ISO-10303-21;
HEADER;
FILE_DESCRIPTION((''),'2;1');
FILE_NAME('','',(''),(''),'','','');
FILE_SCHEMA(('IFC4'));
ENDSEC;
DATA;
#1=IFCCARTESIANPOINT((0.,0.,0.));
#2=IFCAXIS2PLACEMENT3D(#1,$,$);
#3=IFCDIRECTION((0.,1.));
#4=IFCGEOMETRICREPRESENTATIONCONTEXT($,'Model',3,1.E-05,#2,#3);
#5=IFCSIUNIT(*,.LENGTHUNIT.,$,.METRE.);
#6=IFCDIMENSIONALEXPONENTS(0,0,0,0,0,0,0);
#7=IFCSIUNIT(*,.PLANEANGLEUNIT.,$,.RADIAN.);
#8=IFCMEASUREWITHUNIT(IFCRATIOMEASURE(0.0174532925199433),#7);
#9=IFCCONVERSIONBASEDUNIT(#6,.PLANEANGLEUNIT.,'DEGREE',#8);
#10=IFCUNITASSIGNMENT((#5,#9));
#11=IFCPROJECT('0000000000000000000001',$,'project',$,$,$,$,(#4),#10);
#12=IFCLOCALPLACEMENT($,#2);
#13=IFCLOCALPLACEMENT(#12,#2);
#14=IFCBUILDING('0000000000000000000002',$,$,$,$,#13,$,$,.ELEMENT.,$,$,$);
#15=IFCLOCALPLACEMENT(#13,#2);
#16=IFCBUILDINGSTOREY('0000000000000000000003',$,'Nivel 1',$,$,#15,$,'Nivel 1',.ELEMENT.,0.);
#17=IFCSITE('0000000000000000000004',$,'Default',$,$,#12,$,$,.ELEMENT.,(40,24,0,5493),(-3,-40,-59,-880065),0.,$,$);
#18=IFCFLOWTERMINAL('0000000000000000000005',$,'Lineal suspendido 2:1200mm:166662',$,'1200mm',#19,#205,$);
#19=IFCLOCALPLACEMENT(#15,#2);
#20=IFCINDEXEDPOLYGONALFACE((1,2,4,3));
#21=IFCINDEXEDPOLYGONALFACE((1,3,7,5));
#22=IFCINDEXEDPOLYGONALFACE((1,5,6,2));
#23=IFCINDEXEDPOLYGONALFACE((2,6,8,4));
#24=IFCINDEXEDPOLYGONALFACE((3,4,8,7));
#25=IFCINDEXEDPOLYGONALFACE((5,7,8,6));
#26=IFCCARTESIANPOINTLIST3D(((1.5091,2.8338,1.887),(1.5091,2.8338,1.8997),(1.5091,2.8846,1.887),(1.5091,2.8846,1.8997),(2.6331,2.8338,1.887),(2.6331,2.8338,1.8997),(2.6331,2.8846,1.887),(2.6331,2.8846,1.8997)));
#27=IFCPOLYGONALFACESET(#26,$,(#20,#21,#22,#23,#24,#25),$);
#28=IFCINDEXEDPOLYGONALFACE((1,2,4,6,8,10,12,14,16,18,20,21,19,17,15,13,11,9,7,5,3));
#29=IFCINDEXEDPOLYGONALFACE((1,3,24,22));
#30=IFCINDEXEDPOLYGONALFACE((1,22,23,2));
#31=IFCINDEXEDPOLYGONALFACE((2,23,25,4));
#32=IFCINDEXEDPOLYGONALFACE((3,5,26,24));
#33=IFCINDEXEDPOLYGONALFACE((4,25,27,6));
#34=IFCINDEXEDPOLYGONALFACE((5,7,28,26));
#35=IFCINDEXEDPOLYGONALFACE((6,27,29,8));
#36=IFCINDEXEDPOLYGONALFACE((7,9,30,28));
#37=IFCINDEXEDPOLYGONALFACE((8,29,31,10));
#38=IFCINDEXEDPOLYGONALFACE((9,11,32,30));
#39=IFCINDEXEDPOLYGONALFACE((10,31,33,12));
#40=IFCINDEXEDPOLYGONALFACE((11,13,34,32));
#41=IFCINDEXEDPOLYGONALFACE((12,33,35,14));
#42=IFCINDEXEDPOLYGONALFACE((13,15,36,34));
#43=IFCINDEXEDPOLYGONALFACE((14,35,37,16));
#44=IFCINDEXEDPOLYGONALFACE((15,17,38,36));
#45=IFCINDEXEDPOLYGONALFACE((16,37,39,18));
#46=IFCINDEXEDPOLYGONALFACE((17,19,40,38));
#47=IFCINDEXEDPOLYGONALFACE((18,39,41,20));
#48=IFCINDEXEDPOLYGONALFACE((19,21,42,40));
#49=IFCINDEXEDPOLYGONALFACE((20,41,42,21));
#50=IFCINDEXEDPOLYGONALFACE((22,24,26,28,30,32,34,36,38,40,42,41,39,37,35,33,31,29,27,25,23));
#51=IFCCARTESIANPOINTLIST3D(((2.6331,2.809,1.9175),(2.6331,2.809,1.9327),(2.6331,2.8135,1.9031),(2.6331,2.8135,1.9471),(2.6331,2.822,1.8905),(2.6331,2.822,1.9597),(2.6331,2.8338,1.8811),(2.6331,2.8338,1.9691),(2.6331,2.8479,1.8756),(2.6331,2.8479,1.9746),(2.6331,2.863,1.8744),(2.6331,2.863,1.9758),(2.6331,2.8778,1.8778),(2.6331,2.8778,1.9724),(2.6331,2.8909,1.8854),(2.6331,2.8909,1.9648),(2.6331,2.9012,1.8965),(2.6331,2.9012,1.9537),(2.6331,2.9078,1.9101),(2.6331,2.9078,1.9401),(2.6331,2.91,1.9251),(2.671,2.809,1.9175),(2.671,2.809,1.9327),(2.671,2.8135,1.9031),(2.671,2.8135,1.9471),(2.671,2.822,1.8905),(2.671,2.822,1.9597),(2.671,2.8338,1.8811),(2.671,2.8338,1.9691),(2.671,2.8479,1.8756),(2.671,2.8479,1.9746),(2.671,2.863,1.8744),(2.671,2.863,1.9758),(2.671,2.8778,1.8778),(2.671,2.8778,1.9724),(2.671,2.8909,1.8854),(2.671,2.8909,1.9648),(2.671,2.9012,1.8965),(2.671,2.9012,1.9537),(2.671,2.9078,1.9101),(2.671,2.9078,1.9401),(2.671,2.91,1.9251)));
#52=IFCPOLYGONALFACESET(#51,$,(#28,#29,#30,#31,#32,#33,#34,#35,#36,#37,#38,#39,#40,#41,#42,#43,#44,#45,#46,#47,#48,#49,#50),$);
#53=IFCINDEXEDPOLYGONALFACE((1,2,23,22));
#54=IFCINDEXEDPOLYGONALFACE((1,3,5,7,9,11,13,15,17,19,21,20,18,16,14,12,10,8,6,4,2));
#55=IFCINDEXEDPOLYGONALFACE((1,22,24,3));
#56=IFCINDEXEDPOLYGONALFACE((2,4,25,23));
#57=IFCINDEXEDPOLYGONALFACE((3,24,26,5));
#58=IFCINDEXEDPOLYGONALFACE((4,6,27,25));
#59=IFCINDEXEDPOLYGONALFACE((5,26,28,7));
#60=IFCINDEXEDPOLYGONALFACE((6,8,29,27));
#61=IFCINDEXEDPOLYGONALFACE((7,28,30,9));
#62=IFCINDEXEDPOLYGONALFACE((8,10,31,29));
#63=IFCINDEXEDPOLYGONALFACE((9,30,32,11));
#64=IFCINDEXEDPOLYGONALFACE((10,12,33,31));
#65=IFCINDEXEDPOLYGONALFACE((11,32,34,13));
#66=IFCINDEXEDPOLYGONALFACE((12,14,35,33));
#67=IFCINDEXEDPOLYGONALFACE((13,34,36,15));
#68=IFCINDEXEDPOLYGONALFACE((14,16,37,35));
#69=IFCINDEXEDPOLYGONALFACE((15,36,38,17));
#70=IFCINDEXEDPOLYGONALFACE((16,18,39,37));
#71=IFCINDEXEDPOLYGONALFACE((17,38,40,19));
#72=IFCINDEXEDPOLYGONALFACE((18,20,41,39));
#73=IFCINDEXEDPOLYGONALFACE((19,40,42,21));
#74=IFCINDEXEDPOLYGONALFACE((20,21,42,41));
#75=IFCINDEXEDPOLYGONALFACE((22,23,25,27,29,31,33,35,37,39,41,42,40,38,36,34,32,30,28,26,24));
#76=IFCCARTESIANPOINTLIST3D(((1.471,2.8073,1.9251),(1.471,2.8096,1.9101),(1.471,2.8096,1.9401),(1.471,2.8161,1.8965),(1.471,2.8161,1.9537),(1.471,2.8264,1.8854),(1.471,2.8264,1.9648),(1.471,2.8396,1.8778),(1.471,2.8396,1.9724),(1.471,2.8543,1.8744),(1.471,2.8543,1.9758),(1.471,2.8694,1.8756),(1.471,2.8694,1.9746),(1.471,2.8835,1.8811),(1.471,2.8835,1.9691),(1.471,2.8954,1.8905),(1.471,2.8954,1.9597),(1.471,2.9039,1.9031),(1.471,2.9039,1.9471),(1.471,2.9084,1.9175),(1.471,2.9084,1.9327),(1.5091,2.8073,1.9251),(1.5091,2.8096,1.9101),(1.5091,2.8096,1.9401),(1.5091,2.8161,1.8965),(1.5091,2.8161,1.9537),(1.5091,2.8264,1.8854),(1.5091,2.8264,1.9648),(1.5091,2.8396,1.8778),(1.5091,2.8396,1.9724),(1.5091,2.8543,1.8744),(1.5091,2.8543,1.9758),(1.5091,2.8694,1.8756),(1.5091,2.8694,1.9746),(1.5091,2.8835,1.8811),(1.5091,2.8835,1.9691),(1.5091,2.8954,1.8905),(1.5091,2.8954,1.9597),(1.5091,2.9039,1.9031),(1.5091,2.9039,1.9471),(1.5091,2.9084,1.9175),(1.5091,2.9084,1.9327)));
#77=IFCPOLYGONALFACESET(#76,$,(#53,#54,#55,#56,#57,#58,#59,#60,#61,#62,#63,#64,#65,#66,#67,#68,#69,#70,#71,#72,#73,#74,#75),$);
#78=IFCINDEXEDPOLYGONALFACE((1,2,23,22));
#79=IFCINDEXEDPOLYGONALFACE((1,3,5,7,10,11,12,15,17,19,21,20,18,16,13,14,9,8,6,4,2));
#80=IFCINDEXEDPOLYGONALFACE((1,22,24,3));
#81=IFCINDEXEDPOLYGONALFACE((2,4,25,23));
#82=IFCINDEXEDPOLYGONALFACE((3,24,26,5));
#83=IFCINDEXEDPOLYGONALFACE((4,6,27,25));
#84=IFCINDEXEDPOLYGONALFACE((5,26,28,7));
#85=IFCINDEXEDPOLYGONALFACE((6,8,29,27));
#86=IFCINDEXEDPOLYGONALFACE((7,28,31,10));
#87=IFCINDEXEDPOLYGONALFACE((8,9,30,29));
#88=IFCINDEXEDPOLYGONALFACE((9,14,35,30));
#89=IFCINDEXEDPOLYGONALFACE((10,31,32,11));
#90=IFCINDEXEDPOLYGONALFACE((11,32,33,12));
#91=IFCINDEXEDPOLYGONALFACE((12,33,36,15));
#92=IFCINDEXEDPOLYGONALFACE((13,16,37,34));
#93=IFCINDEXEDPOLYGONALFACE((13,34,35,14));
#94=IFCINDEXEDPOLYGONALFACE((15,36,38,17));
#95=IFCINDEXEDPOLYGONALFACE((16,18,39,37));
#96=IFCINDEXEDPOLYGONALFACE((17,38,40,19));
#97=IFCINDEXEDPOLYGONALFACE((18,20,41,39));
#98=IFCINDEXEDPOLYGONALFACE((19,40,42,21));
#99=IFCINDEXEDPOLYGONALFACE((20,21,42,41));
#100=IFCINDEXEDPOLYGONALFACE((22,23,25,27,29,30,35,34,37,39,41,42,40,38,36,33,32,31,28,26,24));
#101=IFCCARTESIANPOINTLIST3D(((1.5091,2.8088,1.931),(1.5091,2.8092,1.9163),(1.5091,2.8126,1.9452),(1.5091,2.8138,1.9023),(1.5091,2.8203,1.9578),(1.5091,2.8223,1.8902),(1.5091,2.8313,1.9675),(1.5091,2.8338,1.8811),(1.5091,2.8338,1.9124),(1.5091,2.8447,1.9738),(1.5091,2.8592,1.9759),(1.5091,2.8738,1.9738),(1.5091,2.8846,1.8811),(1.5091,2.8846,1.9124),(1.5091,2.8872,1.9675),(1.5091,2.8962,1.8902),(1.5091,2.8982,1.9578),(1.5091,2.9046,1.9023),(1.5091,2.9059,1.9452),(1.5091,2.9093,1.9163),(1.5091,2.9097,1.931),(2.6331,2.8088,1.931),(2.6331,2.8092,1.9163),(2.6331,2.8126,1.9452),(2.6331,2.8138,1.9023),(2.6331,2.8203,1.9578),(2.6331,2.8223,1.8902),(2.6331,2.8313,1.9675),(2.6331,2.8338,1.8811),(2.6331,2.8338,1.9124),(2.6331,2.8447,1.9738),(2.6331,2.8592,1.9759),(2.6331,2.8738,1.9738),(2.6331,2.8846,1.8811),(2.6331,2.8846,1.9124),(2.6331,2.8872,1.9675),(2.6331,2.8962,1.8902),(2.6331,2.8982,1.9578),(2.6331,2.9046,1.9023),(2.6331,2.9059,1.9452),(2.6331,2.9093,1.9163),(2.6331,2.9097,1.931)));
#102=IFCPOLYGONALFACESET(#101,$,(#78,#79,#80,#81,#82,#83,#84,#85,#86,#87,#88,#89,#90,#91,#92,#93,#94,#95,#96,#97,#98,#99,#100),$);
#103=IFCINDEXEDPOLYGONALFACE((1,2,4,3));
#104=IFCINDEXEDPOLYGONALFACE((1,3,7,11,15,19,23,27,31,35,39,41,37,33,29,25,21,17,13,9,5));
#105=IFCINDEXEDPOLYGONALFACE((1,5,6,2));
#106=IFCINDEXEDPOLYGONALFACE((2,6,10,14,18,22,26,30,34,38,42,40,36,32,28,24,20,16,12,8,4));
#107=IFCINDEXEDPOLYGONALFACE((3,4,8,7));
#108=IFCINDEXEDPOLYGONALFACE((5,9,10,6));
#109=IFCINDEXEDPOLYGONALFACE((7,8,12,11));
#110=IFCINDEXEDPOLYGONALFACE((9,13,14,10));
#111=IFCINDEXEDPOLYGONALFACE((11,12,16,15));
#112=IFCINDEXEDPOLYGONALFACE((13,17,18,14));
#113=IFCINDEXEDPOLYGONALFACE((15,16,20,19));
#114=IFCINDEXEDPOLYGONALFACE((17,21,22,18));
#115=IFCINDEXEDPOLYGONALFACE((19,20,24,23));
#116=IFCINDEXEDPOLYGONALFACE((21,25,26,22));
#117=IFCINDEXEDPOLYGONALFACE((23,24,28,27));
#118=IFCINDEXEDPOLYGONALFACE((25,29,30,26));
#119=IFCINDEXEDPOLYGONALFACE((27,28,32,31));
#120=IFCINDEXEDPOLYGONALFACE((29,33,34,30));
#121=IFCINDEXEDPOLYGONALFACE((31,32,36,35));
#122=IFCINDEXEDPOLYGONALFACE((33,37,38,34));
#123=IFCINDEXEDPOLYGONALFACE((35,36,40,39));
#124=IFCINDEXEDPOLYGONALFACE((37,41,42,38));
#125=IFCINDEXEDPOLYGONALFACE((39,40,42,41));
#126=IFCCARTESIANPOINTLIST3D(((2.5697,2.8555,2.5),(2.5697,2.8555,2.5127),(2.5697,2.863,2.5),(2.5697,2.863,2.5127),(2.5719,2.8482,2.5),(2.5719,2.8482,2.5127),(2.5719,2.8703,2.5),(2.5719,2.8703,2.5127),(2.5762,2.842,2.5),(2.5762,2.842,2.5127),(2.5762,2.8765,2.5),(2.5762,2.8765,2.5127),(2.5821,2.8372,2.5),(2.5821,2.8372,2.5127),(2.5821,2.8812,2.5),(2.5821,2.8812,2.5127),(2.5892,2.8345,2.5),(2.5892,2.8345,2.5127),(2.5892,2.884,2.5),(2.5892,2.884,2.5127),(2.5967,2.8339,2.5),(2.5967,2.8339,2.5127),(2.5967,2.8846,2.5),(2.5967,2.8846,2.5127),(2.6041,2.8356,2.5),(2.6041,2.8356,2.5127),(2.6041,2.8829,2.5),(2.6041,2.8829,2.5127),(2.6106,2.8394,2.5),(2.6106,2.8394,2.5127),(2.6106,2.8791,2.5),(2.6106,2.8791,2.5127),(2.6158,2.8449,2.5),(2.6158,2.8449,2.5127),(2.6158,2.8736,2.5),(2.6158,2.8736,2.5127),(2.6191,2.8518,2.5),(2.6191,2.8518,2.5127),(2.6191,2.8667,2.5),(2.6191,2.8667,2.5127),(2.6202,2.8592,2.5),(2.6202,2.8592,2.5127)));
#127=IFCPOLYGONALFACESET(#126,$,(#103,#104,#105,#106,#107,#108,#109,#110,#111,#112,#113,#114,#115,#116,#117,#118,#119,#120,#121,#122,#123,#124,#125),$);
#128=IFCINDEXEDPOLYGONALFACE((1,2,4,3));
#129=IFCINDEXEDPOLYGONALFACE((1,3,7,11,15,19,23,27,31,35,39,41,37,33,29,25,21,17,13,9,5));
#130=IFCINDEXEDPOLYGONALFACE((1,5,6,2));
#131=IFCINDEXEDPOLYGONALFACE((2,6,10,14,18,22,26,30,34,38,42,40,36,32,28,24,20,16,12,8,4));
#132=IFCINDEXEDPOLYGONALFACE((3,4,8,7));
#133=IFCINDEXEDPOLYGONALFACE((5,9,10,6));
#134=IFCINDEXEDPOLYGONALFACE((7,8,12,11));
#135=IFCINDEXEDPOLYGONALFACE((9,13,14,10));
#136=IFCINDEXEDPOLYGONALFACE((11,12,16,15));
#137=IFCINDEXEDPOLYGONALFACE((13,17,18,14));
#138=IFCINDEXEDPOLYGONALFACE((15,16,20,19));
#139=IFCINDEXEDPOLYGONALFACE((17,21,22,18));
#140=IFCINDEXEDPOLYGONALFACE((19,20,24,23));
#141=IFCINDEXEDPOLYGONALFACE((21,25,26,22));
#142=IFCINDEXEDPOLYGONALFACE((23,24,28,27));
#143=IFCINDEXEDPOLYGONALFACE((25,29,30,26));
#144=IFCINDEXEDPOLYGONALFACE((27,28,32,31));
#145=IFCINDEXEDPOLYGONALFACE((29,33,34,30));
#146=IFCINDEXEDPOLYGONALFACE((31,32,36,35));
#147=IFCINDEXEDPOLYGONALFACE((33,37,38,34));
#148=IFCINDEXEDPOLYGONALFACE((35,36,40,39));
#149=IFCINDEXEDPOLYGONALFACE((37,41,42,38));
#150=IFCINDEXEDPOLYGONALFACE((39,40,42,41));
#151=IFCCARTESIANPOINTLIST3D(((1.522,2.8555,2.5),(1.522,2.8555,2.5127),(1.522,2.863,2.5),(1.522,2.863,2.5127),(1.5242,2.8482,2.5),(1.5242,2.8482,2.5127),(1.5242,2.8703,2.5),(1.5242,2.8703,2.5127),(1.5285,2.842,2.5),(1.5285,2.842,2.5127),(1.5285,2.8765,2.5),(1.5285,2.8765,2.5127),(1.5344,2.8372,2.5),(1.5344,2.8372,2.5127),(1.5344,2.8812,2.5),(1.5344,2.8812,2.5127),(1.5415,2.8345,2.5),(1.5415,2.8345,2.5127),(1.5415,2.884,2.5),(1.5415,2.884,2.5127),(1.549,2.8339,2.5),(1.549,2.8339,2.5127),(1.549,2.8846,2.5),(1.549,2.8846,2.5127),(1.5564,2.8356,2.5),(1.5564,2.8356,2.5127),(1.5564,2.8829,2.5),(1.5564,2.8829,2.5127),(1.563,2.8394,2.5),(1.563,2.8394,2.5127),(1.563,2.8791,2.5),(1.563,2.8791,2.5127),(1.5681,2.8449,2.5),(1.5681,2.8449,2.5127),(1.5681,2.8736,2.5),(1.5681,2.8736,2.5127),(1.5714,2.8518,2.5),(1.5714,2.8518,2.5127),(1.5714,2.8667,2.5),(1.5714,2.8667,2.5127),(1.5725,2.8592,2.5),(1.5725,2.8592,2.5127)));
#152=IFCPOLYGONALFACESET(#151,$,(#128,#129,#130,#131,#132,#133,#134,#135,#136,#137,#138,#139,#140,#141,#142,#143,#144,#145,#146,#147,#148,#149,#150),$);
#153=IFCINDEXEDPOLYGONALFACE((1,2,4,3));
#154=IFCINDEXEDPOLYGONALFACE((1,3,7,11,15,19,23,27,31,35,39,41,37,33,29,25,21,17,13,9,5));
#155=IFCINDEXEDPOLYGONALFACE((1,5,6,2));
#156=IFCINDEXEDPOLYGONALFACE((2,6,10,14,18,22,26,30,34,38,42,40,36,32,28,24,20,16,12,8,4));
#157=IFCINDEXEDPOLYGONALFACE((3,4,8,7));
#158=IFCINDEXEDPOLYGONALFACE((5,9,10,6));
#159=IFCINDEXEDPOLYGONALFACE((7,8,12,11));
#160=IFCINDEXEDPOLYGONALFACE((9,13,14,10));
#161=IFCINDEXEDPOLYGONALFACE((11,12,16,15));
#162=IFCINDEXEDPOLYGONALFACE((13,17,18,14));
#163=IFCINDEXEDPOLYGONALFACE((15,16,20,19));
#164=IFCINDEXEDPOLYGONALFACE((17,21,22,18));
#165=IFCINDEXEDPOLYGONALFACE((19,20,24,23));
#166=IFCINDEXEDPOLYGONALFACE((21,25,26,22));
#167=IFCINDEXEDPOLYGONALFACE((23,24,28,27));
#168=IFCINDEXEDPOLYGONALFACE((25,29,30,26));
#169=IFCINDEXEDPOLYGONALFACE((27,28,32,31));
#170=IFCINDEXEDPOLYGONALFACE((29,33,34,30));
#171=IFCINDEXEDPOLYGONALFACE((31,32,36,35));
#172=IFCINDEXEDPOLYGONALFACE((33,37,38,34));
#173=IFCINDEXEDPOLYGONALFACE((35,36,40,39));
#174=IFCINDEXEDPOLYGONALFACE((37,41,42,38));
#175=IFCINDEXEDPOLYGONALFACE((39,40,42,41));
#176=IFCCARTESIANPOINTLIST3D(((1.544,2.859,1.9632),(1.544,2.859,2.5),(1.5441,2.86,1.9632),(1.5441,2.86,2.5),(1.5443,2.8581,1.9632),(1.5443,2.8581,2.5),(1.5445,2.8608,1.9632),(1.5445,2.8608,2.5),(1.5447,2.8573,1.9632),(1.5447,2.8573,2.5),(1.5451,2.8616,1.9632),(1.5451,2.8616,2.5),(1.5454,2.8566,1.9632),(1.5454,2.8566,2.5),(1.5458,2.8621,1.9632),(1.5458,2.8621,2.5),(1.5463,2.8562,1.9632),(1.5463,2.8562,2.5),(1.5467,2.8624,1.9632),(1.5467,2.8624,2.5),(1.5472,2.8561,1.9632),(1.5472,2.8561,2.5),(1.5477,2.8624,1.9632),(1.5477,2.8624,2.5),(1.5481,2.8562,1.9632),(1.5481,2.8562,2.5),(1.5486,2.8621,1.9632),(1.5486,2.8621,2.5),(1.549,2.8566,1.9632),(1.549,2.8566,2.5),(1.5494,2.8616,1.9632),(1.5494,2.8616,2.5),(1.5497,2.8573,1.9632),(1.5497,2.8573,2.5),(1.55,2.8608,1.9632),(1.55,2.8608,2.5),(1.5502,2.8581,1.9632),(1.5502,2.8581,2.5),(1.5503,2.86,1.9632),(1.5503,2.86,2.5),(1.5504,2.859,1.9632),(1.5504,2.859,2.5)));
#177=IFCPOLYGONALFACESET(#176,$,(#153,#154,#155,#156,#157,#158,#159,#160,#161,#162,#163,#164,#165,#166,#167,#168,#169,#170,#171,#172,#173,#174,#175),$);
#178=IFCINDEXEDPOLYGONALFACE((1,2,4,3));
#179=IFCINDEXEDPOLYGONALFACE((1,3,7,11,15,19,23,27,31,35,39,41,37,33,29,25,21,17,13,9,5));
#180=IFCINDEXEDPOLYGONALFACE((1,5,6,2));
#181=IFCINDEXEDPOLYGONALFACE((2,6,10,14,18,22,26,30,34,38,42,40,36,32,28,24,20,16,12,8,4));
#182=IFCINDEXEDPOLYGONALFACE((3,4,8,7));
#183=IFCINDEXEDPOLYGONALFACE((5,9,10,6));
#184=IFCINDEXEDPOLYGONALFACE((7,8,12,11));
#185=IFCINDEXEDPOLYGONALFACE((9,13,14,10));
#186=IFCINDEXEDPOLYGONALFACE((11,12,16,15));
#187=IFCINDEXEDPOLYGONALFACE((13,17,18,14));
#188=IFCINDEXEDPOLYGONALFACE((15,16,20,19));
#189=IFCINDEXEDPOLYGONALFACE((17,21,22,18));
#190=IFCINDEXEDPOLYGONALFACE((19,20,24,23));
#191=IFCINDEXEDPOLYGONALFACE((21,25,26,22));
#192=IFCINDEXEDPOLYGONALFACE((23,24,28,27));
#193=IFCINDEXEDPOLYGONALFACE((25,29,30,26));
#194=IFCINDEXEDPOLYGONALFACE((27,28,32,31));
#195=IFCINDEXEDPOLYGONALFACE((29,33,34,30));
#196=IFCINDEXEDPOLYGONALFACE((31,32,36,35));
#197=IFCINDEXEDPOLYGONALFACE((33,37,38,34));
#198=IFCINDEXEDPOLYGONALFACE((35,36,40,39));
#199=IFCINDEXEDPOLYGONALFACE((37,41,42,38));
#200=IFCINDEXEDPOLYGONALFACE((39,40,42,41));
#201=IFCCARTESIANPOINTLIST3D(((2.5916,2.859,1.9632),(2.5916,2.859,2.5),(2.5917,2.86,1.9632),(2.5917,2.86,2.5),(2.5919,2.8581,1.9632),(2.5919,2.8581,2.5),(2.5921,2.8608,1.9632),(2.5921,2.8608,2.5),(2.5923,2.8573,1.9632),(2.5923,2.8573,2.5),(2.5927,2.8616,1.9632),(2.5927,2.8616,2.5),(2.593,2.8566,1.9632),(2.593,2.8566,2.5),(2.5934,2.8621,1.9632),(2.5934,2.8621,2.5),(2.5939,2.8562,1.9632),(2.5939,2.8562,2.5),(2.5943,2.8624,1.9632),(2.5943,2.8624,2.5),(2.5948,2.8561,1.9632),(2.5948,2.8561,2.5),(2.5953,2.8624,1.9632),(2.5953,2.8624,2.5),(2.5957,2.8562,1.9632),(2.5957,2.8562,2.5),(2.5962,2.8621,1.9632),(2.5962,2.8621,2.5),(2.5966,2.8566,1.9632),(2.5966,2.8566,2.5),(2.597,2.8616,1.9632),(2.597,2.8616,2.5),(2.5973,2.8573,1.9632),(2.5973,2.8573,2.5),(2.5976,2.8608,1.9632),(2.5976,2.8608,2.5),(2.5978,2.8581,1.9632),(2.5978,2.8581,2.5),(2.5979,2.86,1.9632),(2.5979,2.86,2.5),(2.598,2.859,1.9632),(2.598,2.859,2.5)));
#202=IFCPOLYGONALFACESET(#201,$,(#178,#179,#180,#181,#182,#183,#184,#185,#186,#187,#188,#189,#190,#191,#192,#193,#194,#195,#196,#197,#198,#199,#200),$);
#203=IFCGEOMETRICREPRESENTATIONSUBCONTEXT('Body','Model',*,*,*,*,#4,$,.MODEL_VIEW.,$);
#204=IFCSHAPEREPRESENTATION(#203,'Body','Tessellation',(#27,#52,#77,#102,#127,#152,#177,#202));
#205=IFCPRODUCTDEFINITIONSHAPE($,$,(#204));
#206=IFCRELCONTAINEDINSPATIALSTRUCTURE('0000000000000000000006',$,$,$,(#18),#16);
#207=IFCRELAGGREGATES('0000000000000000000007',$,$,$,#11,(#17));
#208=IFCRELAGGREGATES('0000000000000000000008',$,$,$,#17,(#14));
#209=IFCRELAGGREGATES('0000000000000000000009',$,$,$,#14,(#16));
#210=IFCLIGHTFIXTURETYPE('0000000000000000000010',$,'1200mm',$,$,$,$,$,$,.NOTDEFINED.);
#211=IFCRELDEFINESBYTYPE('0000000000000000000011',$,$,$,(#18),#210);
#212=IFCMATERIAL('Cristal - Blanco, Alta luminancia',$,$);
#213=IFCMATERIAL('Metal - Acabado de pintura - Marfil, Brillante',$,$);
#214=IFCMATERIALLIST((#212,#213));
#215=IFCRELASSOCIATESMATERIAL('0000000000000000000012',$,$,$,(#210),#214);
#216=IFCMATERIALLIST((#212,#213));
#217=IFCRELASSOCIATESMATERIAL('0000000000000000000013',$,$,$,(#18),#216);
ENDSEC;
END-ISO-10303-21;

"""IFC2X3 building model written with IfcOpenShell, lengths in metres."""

from ifc_helpers import new_model, entity, si_unit, converted_unit, direction, frame, frame_2d, origin, origin_2d_with_axis, place, context, subcontext, project, spatial, polyline, circle_curve, parameter, trimmed, segment, composite_curve, rectangle, circle, outline, extrude, source, transform, mapped, material, material_list, type_object, type_shapes, element, save


model = new_model("IFC2X3")

# Units and contexts
model_context = context("Model", 3, precision=1e-05, world=origin(), true_north=direction((0.0, 1.0)))
body_context = subcontext(model_context, "Body", "Model", "MODEL_VIEW")
ifc_project = project(units=[si_unit("LENGTHUNIT", "METRE"), converted_unit("PLANEANGLEUNIT", "DEGREE", entity("IfcRatioMeasure", 0.0174532925199433), si_unit("PLANEANGLEUNIT", "RADIAN"), dimensions=[0, 0, 0, 0, 0, 0, 0])], contexts=[model_context])

# Site, building, storey
site_placement = place(None, origin())
site = spatial("IfcSite", under=ifc_project, at=site_placement, Name="Default", CompositionType="ELEMENT", RefLatitude=(40, 24, 0, 5493), RefLongitude=(-3, -40, -59, -880065), RefElevation=0.0)
building_placement = place(site_placement, origin())
building = spatial("IfcBuilding", under=site, at=building_placement, CompositionType="ELEMENT")
storey_placement = place(building_placement, origin())
storey = spatial("IfcBuildingStorey", under=building, at=storey_placement, Name="Nivel 1", LongName="Nivel 1", CompositionType="ELEMENT", Elevation=0.0)

# Flow terminal
ifc_material_1 = material(Name="Cristal - Blanco, Alta luminancia")
ifc_material_2 = material(Name="Metal - Acabado de pintura - Marfil, Brillante")
ifc_material_list_1 = material_list([ifc_material_1, ifc_material_2])
light_fixture_type = type_object("IfcLightFixtureType", Name="1200mm", PredefinedType="NOTDEFINED", material=ifc_material_list_1)
shared_shape = source(origin(), body_context, "Body", "SweptSolid", [
    extrude(rectangle(XDim=1.124, YDim=0.0508, at=origin_2d_with_axis()), frame((0.0001, 0.0, 1.8127), z_axis=(0.0, 0.0, 1.0), x_axis=(-1.0, 0.0, 0.0)), (0.0, 0.0, 1.0), 0.0127),
    extrude(circle(Radius=0.0508, at=frame_2d((0.0, 0.0), x_axis=(1.0, 0.0))), frame((0.5621, 0.0, 1.8508), z_axis=(1.0, 0.0, 0.0), x_axis=(0.0, 1.0, 0.0)), (0.0, 0.0, 1.0), 0.0379),
    extrude(circle(Radius=0.0508, at=frame_2d((0.0, 0.0), x_axis=(1.0, 0.0))), frame((-0.6, -0.0011, 1.8508), z_axis=(1.0, 0.0, 0.0), x_axis=(0.0, -1.0, 0.0)), (0.0, 0.0, 1.0), 0.0381),
    extrude(outline(composite_curve([segment(trimmed(circle_curve(frame_2d((0.0125, 0.0), x_axis=(0.0, 1.0)), 0.0508), [parameter(120.0)], [parameter(270.0)], True, "PARAMETER"), True, "CONTINUOUS"), segment(trimmed(circle_curve(frame_2d((0.0125, 0.0), x_axis=(0.0, 1.0)), 0.0508), [parameter(270.0)], [parameter(60.0)], True, "PARAMETER"), True, "CONTINUOUS"), segment(polyline([(-0.0315, 0.0254), (-0.0002, 0.0254)]), True, "CONTINUOUS"), segment(polyline([(-0.0002, 0.0254), (-0.0002, -0.0254)]), True, "CONTINUOUS"), segment(polyline([(-0.0002, -0.0254), (-0.0315, -0.0254)]), True, "CONTINUOUS")], self_intersect=False)), frame((-0.5619, 0.0, 1.8383), z_axis=(-1.0, 0.0, 0.0), x_axis=(0.0, 0.0, 1.0)), (0.0, 0.0, -1.0), 1.124),
    extrude(circle(Radius=0.0254, at=frame_2d((0.0, 0.0), x_axis=(1.0, 0.0))), frame((0.5238, 0.0, 2.4257)), (0.0, 0.0, 1.0), 0.0127),
    extrude(circle(Radius=0.0254, at=frame_2d((0.0, 0.0), x_axis=(1.0, 0.0))), frame((-0.5239, 0.0, 2.4257)), (0.0, 0.0, 1.0), 0.0127),
    extrude(circle(Radius=0.0032, at=frame_2d((0.0, 0.0), x_axis=(1.0, 0.0))), frame((-0.5238, 0.0, 1.8889), z_axis=(0.0, 0.0, 1.0), x_axis=(0.0, -1.0, 0.0)), (0.0, 0.0, 1.0), 0.5368),
    extrude(circle(Radius=0.0032, at=frame_2d((0.0, 0.0), x_axis=(1.0, 0.0))), frame((0.5238, 0.0, 1.8889), z_axis=(0.0, 0.0, 1.0), x_axis=(0.0, -1.0, 0.0)), (0.0, 0.0, 1.0), 0.5368),
])
type_shapes(light_fixture_type, [shared_shape])
ifc_material_list_2 = material_list([ifc_material_1, ifc_material_2])
flow_terminal_1_placement = place(storey_placement, frame((2.071, 2.8592, 0.0743)))
element("IfcFlowTerminal", 1, at=flow_terminal_1_placement, inside=storey, type_object=light_fixture_type, material=ifc_material_list_2, Name="Lineal suspendido 2:1200mm:166662", ObjectType="1200mm", context=body_context, shape_type="MappedRepresentation", body=[
    mapped(shared_shape, transform((0.0, 0.0, 0.0), scale=1.0)),
])

save(model, "model.ifc")
